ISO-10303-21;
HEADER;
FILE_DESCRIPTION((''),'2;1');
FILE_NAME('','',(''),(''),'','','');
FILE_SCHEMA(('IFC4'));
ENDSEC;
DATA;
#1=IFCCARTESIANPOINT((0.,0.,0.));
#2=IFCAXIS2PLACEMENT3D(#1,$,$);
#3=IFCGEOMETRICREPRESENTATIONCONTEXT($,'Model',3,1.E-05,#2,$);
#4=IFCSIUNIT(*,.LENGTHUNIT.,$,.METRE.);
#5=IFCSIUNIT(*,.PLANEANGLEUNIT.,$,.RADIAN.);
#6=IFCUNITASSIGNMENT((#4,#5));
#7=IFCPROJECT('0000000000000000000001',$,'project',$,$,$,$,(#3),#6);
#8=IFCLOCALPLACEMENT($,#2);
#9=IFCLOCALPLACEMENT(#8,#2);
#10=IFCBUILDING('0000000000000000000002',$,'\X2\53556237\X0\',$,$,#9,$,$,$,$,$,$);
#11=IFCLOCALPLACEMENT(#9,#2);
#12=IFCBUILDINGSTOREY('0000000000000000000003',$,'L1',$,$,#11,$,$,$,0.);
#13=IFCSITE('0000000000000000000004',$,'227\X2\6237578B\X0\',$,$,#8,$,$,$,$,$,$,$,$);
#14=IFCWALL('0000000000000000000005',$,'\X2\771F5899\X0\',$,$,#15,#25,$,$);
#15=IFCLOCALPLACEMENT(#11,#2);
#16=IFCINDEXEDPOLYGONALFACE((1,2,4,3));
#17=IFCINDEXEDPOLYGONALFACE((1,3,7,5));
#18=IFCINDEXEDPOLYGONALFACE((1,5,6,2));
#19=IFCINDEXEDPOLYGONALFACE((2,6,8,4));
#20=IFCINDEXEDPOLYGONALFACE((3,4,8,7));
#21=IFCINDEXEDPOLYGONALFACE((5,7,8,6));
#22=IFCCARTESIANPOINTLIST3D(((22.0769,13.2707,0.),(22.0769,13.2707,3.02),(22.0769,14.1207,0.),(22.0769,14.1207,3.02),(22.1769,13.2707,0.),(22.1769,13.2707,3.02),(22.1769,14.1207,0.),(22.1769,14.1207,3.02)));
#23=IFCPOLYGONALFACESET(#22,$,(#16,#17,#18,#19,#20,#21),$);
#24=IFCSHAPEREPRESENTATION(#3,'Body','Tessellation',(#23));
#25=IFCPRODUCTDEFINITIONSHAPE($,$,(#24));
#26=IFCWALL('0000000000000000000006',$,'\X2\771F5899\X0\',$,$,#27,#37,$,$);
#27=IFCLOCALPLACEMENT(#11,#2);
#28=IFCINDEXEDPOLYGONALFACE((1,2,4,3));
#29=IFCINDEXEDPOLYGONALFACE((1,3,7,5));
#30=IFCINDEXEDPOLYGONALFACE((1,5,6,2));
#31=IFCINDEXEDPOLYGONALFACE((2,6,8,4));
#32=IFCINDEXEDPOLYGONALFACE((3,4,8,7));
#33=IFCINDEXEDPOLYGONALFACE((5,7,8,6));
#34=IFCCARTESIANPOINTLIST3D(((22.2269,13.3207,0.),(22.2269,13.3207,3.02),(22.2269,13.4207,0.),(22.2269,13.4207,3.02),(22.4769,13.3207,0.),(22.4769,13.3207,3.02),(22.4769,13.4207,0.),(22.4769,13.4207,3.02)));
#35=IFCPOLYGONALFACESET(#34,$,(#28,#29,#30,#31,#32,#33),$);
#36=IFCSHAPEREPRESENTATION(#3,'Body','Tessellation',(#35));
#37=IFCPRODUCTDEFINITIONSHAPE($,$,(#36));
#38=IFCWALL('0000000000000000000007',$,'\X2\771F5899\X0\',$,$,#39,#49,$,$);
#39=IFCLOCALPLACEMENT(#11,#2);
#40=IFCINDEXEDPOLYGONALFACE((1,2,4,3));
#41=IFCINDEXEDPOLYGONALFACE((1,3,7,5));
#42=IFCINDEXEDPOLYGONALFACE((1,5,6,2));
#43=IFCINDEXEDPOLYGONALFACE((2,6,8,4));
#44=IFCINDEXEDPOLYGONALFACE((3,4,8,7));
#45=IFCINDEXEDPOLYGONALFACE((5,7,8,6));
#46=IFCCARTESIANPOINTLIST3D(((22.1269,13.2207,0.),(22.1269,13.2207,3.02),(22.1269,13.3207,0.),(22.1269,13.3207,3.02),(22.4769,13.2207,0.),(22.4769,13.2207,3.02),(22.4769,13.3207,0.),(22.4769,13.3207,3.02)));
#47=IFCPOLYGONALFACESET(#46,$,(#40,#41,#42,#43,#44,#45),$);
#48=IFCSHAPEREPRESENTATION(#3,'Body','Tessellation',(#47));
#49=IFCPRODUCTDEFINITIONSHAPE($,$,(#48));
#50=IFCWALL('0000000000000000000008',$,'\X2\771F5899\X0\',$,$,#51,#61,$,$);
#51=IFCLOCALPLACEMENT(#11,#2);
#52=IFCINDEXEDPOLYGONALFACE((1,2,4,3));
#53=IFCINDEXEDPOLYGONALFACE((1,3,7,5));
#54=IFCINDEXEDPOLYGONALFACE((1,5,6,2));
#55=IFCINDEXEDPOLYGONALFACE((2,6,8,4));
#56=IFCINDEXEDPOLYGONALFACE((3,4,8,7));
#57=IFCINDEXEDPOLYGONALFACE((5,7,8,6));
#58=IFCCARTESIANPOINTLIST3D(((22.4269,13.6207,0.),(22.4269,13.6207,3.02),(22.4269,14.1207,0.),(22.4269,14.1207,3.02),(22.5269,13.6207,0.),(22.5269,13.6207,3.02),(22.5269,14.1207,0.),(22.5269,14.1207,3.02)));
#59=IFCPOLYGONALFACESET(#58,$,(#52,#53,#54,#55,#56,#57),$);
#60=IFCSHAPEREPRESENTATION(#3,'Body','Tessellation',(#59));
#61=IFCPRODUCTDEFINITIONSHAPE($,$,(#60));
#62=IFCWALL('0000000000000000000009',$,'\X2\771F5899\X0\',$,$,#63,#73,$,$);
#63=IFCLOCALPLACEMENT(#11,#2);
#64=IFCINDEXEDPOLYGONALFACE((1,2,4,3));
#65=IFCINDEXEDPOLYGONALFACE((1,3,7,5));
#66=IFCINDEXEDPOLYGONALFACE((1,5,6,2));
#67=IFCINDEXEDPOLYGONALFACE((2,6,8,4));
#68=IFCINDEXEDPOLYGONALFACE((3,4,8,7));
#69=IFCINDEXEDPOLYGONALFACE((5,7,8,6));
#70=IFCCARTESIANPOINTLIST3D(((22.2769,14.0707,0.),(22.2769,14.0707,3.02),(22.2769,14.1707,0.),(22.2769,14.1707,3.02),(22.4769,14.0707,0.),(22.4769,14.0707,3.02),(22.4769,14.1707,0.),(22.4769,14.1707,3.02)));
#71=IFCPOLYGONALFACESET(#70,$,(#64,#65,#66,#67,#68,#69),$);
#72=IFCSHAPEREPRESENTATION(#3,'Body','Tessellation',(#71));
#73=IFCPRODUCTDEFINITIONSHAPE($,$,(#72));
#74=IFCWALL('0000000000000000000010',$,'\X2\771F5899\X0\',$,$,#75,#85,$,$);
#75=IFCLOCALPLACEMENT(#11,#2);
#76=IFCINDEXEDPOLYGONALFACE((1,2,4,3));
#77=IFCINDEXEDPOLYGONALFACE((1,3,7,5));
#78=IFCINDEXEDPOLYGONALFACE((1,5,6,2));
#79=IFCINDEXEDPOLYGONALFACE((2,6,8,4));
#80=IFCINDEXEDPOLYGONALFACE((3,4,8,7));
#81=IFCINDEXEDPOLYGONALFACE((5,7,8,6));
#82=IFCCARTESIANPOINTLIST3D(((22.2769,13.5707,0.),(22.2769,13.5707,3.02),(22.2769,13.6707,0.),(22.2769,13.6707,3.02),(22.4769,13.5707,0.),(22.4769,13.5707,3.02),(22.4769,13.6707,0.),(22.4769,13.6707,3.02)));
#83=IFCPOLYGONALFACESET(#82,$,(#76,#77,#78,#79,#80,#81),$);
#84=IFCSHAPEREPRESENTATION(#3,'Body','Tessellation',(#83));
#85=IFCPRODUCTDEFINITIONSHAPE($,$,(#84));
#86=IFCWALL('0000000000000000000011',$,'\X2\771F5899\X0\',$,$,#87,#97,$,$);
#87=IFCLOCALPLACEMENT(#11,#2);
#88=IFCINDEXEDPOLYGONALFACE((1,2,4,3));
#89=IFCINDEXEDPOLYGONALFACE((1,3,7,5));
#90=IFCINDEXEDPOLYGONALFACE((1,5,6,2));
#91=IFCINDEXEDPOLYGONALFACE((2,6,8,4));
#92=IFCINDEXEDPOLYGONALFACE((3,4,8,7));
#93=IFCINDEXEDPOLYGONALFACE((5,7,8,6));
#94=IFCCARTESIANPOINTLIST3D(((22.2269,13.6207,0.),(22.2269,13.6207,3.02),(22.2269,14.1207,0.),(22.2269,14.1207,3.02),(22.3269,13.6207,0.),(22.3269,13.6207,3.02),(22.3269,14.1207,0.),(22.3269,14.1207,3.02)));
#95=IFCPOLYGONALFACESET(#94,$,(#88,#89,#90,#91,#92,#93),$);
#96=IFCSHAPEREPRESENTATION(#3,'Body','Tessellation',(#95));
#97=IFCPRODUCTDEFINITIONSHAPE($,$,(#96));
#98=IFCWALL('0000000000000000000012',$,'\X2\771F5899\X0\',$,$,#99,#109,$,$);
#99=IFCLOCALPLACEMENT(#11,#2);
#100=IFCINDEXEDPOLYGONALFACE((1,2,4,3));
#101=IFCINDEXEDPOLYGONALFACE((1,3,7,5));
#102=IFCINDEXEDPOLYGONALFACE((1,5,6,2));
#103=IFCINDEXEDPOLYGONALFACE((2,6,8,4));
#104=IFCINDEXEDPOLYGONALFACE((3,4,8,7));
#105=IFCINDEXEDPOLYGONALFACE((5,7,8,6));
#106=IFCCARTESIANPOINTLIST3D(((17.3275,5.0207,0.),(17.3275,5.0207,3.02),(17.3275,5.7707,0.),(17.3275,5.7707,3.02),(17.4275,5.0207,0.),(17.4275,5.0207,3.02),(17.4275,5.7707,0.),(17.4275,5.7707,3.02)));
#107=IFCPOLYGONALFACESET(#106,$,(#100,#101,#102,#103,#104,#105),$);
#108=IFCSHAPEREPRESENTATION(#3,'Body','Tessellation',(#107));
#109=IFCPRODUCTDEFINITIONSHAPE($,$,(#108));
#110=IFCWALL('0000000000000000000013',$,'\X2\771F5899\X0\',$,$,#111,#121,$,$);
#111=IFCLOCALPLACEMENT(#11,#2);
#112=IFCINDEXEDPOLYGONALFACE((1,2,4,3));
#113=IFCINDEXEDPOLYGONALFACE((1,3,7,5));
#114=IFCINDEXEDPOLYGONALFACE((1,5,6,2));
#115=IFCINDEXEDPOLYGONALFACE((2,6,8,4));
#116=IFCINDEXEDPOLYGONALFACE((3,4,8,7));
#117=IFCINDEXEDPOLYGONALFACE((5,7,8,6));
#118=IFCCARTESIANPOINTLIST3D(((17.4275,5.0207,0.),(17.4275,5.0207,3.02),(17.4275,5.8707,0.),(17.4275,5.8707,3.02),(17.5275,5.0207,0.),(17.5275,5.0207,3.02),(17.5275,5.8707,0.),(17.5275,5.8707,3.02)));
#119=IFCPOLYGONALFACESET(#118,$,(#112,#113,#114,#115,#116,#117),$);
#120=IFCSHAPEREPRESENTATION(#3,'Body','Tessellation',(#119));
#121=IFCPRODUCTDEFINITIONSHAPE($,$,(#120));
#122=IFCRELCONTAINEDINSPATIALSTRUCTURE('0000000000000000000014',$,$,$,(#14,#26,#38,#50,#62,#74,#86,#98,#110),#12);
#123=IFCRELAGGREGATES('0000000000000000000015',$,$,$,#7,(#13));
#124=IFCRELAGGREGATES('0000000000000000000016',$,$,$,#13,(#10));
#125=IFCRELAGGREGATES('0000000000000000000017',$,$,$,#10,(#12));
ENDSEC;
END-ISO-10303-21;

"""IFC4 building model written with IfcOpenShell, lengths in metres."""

from ifc_helpers import new_model, si_unit, origin, place, context, project, spatial, polyline, outline, extrude, element, save


model = new_model("IFC4")

# Units and contexts
model_context = context("Model", 3, precision=1e-05, world=origin())
ifc_project = project(units=[si_unit("LENGTHUNIT", "METRE"), si_unit("PLANEANGLEUNIT", "RADIAN")], contexts=[model_context])

# Site, building, storey
site_placement = place(None, origin())
site = spatial("IfcSite", under=ifc_project, at=site_placement, Name="227户型")
building_placement = place(site_placement, origin())
building = spatial("IfcBuilding", under=site, at=building_placement, Name="单户")
storey_placement = place(building_placement, origin())
storey = spatial("IfcBuildingStorey", under=building, at=storey_placement, Name="L1", Elevation=0.0)

# Walls
wall_1_placement = place(storey_placement, origin())
element("IfcWall", 1, at=wall_1_placement, inside=storey, Name="真墙", context=model_context, shape_type="SweptSolid", body=[
    extrude(outline(polyline([(22.1769, 14.1207), (22.1769, 13.2707), (22.0769, 13.2707), (22.0769, 14.1207), (22.1769, 14.1207)])), origin(), (0.0, 0.0, 1.0), 3.02),
])
wall_2_placement = place(storey_placement, origin())
element("IfcWall", 2, at=wall_2_placement, inside=storey, Name="真墙", context=model_context, shape_type="SweptSolid", body=[
    extrude(outline(polyline([(22.2269, 13.4207), (22.4769, 13.4207), (22.4769, 13.3207), (22.2269, 13.3207), (22.2269, 13.4207)])), origin(), (0.0, 0.0, 1.0), 3.02),
])
wall_3_placement = place(storey_placement, origin())
element("IfcWall", 3, at=wall_3_placement, inside=storey, Name="真墙", context=model_context, shape_type="SweptSolid", body=[
    extrude(outline(polyline([(22.1269, 13.3207), (22.4769, 13.3207), (22.4769, 13.2207), (22.1269, 13.2207), (22.1269, 13.3207)])), origin(), (0.0, 0.0, 1.0), 3.02),
])
wall_4_placement = place(storey_placement, origin())
element("IfcWall", 4, at=wall_4_placement, inside=storey, Name="真墙", context=model_context, shape_type="SweptSolid", body=[
    extrude(outline(polyline([(22.4269, 13.6207), (22.4269, 14.1207), (22.5269, 14.1207), (22.5269, 13.6207), (22.4269, 13.6207)])), origin(), (0.0, 0.0, 1.0), 3.02),
])
wall_5_placement = place(storey_placement, origin())
element("IfcWall", 5, at=wall_5_placement, inside=storey, Name="真墙", context=model_context, shape_type="SweptSolid", body=[
    extrude(outline(polyline([(22.4769, 14.0707), (22.2769, 14.0707), (22.2769, 14.1707), (22.4769, 14.1707), (22.4769, 14.0707)])), origin(), (0.0, 0.0, 1.0), 3.02),
])
wall_6_placement = place(storey_placement, origin())
element("IfcWall", 6, at=wall_6_placement, inside=storey, Name="真墙", context=model_context, shape_type="SweptSolid", body=[
    extrude(outline(polyline([(22.4769, 13.5707), (22.2769, 13.5707), (22.2769, 13.6707), (22.4769, 13.6707), (22.4769, 13.5707)])), origin(), (0.0, 0.0, 1.0), 3.02),
])
wall_7_placement = place(storey_placement, origin())
element("IfcWall", 7, at=wall_7_placement, inside=storey, Name="真墙", context=model_context, shape_type="SweptSolid", body=[
    extrude(outline(polyline([(22.2269, 13.6207), (22.2269, 14.1207), (22.3269, 14.1207), (22.3269, 13.6207), (22.2269, 13.6207)])), origin(), (0.0, 0.0, 1.0), 3.02),
])
wall_8_placement = place(storey_placement, origin())
element("IfcWall", 8, at=wall_8_placement, inside=storey, Name="真墙", context=model_context, shape_type="SweptSolid", body=[
    extrude(outline(polyline([(17.4275, 5.7707), (17.4275, 5.0207), (17.3275, 5.0207), (17.3275, 5.7707), (17.4275, 5.7707)])), origin(), (0.0, 0.0, 1.0), 3.02),
])
wall_9_placement = place(storey_placement, origin())
element("IfcWall", 9, at=wall_9_placement, inside=storey, Name="真墙", context=model_context, shape_type="SweptSolid", body=[
    extrude(outline(polyline([(17.4275, 5.0207), (17.4275, 5.8707), (17.5275, 5.8707), (17.5275, 5.0207), (17.4275, 5.0207)])), origin(), (0.0, 0.0, 1.0), 3.02),
])

save(model, "model.ifc")
